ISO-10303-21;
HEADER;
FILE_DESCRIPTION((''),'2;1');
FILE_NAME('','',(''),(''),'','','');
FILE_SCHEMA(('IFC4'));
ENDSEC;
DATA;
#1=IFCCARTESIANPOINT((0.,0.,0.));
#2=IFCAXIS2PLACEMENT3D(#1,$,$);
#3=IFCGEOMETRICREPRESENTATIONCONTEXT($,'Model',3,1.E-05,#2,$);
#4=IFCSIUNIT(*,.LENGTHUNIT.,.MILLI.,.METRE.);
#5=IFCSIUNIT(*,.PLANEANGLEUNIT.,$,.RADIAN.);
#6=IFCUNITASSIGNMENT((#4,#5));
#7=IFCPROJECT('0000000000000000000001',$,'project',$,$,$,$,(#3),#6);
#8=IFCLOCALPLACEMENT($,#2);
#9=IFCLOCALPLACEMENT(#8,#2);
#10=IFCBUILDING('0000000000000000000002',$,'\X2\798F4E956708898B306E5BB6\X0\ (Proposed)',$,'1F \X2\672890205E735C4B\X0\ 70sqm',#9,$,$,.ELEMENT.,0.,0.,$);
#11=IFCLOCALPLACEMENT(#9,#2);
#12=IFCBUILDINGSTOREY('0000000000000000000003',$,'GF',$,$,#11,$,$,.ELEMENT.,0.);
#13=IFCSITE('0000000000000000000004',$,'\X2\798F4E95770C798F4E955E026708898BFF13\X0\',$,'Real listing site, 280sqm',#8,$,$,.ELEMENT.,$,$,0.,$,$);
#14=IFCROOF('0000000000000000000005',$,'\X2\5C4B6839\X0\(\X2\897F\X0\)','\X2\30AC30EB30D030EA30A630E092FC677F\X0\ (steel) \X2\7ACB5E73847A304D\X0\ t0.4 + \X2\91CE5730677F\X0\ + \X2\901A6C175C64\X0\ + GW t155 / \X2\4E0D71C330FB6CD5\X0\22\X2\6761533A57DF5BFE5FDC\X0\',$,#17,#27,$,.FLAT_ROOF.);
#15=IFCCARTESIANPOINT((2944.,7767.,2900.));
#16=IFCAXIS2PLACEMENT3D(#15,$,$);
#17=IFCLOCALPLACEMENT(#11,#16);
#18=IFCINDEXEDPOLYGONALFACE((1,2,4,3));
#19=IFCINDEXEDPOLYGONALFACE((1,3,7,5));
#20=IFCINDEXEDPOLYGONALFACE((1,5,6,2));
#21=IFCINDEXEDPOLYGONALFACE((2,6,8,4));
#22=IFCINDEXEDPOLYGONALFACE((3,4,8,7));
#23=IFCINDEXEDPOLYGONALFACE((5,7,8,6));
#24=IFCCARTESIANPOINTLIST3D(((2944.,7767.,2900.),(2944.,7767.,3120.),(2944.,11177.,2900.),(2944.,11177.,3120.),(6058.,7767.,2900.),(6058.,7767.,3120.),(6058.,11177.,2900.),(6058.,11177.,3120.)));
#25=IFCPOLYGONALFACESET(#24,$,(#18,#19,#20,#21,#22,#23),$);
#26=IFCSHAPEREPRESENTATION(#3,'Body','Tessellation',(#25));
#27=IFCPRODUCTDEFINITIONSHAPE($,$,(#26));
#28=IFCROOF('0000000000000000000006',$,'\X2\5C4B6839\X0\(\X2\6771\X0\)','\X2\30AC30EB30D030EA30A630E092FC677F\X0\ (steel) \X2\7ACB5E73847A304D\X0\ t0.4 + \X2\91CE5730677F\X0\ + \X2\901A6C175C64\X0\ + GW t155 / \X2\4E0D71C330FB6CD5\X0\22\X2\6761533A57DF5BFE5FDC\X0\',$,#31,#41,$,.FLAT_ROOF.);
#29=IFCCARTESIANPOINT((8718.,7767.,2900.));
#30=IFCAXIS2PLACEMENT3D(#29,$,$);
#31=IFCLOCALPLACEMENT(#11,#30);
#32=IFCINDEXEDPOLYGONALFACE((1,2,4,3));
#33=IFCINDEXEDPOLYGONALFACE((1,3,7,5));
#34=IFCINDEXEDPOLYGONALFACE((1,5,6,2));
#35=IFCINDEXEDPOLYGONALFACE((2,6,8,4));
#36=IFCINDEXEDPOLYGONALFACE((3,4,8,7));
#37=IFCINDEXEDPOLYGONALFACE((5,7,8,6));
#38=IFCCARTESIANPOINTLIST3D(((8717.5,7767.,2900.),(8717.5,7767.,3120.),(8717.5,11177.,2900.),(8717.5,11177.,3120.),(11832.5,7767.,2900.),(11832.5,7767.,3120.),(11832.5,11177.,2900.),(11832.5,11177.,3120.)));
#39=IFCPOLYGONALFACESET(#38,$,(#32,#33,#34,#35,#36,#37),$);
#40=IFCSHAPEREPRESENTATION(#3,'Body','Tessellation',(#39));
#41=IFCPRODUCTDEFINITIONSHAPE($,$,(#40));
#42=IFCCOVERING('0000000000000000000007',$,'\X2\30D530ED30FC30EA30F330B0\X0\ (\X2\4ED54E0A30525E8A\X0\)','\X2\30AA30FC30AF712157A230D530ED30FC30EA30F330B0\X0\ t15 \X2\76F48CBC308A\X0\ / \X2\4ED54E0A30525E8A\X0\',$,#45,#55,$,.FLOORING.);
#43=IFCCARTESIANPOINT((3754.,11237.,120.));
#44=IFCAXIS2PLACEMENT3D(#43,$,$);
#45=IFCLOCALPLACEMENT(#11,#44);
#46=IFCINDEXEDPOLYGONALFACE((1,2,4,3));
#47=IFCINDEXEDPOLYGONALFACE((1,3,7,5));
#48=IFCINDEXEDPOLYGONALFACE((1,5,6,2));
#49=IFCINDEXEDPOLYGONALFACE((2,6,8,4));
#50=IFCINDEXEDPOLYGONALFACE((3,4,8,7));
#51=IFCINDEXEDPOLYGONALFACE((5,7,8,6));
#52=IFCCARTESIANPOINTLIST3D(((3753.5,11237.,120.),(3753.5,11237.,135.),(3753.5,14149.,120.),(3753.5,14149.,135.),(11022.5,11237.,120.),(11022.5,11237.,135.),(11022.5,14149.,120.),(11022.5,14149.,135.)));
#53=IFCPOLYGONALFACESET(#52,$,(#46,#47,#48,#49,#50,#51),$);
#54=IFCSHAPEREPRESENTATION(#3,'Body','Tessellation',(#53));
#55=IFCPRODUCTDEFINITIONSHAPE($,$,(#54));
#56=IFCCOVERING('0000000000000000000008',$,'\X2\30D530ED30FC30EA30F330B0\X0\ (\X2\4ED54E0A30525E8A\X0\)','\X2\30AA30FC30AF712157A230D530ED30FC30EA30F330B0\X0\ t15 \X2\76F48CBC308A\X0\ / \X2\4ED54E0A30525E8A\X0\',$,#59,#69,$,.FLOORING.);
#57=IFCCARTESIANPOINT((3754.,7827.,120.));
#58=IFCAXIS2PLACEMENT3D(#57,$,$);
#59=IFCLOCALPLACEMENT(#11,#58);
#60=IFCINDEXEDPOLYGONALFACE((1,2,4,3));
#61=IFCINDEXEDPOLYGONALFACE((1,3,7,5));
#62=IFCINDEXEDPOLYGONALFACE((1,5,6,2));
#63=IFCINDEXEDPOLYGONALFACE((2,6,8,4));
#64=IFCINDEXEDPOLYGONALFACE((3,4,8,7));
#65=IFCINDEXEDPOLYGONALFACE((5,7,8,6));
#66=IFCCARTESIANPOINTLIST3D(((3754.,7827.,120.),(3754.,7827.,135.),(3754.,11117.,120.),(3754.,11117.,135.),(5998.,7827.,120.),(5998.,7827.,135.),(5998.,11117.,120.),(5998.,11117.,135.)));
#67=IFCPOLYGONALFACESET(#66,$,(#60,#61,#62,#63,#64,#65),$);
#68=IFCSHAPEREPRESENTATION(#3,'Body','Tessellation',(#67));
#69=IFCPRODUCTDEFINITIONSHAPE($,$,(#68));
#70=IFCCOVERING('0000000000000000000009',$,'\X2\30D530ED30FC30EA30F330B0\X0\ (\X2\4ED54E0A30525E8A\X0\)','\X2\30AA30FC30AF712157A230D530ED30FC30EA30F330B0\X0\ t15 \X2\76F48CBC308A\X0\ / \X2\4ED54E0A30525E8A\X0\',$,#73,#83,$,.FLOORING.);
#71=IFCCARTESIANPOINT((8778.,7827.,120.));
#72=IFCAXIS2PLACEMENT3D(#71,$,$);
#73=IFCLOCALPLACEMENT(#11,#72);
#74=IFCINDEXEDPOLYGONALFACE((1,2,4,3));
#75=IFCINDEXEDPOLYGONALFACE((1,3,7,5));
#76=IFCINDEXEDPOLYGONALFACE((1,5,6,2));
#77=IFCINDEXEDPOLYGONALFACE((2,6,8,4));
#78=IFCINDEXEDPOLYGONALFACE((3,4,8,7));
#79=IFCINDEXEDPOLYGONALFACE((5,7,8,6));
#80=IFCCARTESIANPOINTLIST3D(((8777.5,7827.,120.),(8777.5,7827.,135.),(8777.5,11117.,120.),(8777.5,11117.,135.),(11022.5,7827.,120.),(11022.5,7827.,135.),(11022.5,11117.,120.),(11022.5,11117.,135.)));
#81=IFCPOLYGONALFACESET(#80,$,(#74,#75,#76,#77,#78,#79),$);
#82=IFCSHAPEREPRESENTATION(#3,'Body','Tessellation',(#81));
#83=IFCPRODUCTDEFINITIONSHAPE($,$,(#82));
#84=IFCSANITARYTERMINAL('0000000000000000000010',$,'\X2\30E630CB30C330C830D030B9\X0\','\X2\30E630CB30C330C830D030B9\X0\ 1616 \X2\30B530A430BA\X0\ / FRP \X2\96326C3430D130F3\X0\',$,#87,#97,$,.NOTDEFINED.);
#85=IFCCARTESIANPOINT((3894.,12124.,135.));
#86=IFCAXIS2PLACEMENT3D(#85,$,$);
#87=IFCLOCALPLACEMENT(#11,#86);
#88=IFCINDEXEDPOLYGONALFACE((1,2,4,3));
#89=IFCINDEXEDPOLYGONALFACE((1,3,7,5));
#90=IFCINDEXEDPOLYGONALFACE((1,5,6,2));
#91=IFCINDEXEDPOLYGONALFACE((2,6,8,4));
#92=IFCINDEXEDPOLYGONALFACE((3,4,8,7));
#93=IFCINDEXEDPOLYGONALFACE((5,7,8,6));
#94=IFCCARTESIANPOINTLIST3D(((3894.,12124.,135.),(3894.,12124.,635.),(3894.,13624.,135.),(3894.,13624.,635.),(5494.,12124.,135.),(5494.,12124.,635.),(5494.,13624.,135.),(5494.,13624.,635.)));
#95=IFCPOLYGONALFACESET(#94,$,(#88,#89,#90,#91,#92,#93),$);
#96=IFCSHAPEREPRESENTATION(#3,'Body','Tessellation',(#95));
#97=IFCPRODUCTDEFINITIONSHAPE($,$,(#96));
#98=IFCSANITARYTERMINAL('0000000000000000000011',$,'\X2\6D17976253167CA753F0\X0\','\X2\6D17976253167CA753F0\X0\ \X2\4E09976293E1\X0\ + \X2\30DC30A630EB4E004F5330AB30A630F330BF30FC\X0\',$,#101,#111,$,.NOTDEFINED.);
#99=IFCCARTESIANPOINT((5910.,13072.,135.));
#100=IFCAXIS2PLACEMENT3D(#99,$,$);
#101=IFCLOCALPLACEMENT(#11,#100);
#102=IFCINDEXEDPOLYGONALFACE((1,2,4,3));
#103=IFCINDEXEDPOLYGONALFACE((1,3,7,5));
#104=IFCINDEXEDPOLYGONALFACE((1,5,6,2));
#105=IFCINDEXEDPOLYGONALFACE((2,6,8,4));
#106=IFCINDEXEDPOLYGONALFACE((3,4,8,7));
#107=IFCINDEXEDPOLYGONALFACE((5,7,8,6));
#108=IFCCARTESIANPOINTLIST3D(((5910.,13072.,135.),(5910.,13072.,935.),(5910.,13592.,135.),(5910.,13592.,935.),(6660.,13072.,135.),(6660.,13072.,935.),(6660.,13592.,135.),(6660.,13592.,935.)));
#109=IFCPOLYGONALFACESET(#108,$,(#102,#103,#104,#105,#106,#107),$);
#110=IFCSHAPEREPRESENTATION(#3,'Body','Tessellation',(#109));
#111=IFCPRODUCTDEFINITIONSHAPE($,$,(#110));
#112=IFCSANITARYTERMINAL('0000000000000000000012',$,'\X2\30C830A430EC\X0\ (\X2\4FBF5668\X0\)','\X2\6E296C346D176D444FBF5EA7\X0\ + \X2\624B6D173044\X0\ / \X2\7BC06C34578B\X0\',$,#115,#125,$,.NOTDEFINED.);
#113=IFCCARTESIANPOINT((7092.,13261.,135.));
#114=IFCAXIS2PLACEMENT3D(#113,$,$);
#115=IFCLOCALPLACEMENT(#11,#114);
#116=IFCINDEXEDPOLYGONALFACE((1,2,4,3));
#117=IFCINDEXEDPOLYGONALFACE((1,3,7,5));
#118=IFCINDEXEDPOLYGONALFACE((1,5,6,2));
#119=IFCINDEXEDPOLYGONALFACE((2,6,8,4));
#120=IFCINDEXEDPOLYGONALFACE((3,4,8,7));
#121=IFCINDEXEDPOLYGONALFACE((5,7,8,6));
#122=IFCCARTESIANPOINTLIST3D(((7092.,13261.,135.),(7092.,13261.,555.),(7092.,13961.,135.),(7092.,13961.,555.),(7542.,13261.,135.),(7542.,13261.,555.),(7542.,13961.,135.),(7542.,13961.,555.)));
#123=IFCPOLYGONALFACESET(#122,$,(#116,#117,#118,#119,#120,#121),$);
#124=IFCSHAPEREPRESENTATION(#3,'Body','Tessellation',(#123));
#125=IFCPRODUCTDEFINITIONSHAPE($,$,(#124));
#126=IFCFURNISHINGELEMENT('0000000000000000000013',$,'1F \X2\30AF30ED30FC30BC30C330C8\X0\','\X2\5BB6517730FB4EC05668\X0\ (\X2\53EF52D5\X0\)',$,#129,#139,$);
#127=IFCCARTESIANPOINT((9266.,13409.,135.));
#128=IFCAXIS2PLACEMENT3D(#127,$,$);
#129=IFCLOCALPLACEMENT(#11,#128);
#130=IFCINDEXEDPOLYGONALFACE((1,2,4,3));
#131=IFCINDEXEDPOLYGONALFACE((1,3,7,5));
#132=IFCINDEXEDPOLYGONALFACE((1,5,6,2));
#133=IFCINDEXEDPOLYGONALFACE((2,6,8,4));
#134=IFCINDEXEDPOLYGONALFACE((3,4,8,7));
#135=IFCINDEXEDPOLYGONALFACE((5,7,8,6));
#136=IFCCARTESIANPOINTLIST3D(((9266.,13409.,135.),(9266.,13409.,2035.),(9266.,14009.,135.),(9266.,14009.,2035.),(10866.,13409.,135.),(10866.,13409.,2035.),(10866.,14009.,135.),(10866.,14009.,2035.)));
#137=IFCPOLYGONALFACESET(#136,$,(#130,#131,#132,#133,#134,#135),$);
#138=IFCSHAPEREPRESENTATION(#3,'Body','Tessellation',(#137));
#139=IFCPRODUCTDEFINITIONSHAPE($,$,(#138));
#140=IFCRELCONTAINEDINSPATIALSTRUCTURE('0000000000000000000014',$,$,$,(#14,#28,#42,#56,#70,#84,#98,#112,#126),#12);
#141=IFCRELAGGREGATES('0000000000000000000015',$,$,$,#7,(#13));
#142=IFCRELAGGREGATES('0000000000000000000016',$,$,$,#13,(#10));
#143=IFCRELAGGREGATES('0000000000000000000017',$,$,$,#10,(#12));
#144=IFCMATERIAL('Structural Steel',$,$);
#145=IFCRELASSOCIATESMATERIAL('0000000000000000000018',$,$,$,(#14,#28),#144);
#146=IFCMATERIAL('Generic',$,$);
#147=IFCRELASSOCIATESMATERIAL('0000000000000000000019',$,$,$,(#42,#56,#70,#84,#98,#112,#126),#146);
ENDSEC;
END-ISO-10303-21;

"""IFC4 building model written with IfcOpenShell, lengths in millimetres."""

from ifc_helpers import new_model, si_unit, frame, frame_2d, origin, place, context, project, spatial, rectangle, extrude, material, element, save


model = new_model("IFC4")

# Units and contexts
model_context = context("Model", 3, precision=1e-05, world=origin())
ifc_project = project(units=[si_unit("LENGTHUNIT", "METRE", prefix="MILLI"), si_unit("PLANEANGLEUNIT", "RADIAN")], contexts=[model_context])

# Site, building, storey
site_placement = place(None, origin())
site = spatial("IfcSite", under=ifc_project, at=site_placement, Name="福井県福井市月見３", ObjectType="Real listing site, 280sqm", CompositionType="ELEMENT", RefElevation=0.0)
building_placement = place(site_placement, origin())
building = spatial("IfcBuilding", under=site, at=building_placement, Name="福井月見の家 (Proposed)", ObjectType="1F 木造平屋 70sqm", CompositionType="ELEMENT", ElevationOfRefHeight=0.0, ElevationOfTerrain=0.0)
storey_placement = place(building_placement, origin())
storey = spatial("IfcBuildingStorey", under=building, at=storey_placement, Name="GF", CompositionType="ELEMENT", Elevation=0.0)

# Roofs
ifc_material_1 = material(Name="Structural Steel")
roof_1_placement = place(storey_placement, frame((2944.0, 7767.0, 2900.0)))
element("IfcRoof", 1, at=roof_1_placement, inside=storey, material=ifc_material_1, Name="屋根(西)", Description="ガルバリウム鋼板 (steel) 立平葺き t0.4 + 野地板 + 通気層 + GW t155 / 不燃・法22条区域対応", PredefinedType="FLAT_ROOF", context=model_context, shape_type="SweptSolid", body=[
    extrude(rectangle(XDim=3114.0, YDim=3410.0, at=frame_2d((1557.0, 1705.0))), frame((2944.0, 7767.0, 2900.0)), (0.0, 0.0, 1.0), 220.0),
])
roof_2_placement = place(storey_placement, frame((8718.0, 7767.0, 2900.0)))
element("IfcRoof", 2, at=roof_2_placement, inside=storey, material=ifc_material_1, Name="屋根(東)", Description="ガルバリウム鋼板 (steel) 立平葺き t0.4 + 野地板 + 通気層 + GW t155 / 不燃・法22条区域対応", PredefinedType="FLAT_ROOF", context=model_context, shape_type="SweptSolid", body=[
    extrude(rectangle(XDim=3115.0, YDim=3410.0, at=frame_2d((1557.0, 1705.0))), frame((8718.0, 7767.0, 2900.0)), (0.0, 0.0, 1.0), 220.0),
])

# Coverings
ifc_material_2 = material(Name="Generic")
covering_1_placement = place(storey_placement, frame((3754.0, 11237.0, 120.0)))
element("IfcCovering", 3, at=covering_1_placement, inside=storey, material=ifc_material_2, Name="フローリング (仕上げ床)", Description="オーク無垢フローリング t15 直貼り / 仕上げ床", PredefinedType="FLOORING", context=model_context, shape_type="SweptSolid", body=[
    extrude(rectangle(XDim=7269.0, YDim=2912.0, at=frame_2d((3634.0, 1456.0))), frame((3754.0, 11237.0, 120.0)), (0.0, 0.0, 1.0), 15.0),
])
covering_2_placement = place(storey_placement, frame((3754.0, 7827.0, 120.0)))
element("IfcCovering", 4, at=covering_2_placement, inside=storey, material=ifc_material_2, Name="フローリング (仕上げ床)", Description="オーク無垢フローリング t15 直貼り / 仕上げ床", PredefinedType="FLOORING", context=model_context, shape_type="SweptSolid", body=[
    extrude(rectangle(XDim=2244.0, YDim=3290.0, at=frame_2d((1122.0, 1645.0))), frame((3754.0, 7827.0, 120.0)), (0.0, 0.0, 1.0), 15.0),
])
covering_3_placement = place(storey_placement, frame((8778.0, 7827.0, 120.0)))
element("IfcCovering", 5, at=covering_3_placement, inside=storey, material=ifc_material_2, Name="フローリング (仕上げ床)", Description="オーク無垢フローリング t15 直貼り / 仕上げ床", PredefinedType="FLOORING", context=model_context, shape_type="SweptSolid", body=[
    extrude(rectangle(XDim=2245.0, YDim=3290.0, at=frame_2d((1122.0, 1645.0))), frame((8778.0, 7827.0, 120.0)), (0.0, 0.0, 1.0), 15.0),
])

# Sanitary terminals
sanitary_terminal_1_placement = place(storey_placement, frame((3894.0, 12124.0, 135.0)))
element("IfcSanitaryTerminal", 6, at=sanitary_terminal_1_placement, inside=storey, material=ifc_material_2, Name="ユニットバス", Description="ユニットバス 1616 サイズ / FRP 防水パン", PredefinedType="NOTDEFINED", context=model_context, shape_type="SweptSolid", body=[
    extrude(rectangle(XDim=1600.0, YDim=1500.0, at=frame_2d((800.0, 750.0))), frame((3894.0, 12124.0, 135.0)), (0.0, 0.0, 1.0), 500.0),
])
sanitary_terminal_2_placement = place(storey_placement, frame((5910.0, 13072.0, 135.0)))
element("IfcSanitaryTerminal", 7, at=sanitary_terminal_2_placement, inside=storey, material=ifc_material_2, Name="洗面化粧台", Description="洗面化粧台 三面鏡 + ボウル一体カウンター", PredefinedType="NOTDEFINED", context=model_context, shape_type="SweptSolid", body=[
    extrude(rectangle(XDim=750.0, YDim=520.0, at=frame_2d((375.0, 260.0))), frame((5910.0, 13072.0, 135.0)), (0.0, 0.0, 1.0), 800.0),
])
sanitary_terminal_3_placement = place(storey_placement, frame((7092.0, 13261.0, 135.0)))
element("IfcSanitaryTerminal", 8, at=sanitary_terminal_3_placement, inside=storey, material=ifc_material_2, Name="トイレ (便器)", Description="温水洗浄便座 + 手洗い / 節水型", PredefinedType="NOTDEFINED", context=model_context, shape_type="SweptSolid", body=[
    extrude(rectangle(XDim=450.0, YDim=700.0, at=frame_2d((225.0, 350.0))), frame((7092.0, 13261.0, 135.0)), (0.0, 0.0, 1.0), 420.0),
])

# Furnishing element
furnishing_placement = place(storey_placement, frame((9266.0, 13409.0, 135.0)))
element("IfcFurnishingElement", 9, at=furnishing_placement, inside=storey, material=ifc_material_2, Name="1F クローゼット", Description="家具・什器 (可動)", context=model_context, shape_type="SweptSolid", body=[
    extrude(rectangle(XDim=1600.0, YDim=600.0, at=frame_2d((800.0, 300.0))), frame((9266.0, 13409.0, 135.0)), (0.0, 0.0, 1.0), 1900.0),
])

save(model, "model.ifc")
